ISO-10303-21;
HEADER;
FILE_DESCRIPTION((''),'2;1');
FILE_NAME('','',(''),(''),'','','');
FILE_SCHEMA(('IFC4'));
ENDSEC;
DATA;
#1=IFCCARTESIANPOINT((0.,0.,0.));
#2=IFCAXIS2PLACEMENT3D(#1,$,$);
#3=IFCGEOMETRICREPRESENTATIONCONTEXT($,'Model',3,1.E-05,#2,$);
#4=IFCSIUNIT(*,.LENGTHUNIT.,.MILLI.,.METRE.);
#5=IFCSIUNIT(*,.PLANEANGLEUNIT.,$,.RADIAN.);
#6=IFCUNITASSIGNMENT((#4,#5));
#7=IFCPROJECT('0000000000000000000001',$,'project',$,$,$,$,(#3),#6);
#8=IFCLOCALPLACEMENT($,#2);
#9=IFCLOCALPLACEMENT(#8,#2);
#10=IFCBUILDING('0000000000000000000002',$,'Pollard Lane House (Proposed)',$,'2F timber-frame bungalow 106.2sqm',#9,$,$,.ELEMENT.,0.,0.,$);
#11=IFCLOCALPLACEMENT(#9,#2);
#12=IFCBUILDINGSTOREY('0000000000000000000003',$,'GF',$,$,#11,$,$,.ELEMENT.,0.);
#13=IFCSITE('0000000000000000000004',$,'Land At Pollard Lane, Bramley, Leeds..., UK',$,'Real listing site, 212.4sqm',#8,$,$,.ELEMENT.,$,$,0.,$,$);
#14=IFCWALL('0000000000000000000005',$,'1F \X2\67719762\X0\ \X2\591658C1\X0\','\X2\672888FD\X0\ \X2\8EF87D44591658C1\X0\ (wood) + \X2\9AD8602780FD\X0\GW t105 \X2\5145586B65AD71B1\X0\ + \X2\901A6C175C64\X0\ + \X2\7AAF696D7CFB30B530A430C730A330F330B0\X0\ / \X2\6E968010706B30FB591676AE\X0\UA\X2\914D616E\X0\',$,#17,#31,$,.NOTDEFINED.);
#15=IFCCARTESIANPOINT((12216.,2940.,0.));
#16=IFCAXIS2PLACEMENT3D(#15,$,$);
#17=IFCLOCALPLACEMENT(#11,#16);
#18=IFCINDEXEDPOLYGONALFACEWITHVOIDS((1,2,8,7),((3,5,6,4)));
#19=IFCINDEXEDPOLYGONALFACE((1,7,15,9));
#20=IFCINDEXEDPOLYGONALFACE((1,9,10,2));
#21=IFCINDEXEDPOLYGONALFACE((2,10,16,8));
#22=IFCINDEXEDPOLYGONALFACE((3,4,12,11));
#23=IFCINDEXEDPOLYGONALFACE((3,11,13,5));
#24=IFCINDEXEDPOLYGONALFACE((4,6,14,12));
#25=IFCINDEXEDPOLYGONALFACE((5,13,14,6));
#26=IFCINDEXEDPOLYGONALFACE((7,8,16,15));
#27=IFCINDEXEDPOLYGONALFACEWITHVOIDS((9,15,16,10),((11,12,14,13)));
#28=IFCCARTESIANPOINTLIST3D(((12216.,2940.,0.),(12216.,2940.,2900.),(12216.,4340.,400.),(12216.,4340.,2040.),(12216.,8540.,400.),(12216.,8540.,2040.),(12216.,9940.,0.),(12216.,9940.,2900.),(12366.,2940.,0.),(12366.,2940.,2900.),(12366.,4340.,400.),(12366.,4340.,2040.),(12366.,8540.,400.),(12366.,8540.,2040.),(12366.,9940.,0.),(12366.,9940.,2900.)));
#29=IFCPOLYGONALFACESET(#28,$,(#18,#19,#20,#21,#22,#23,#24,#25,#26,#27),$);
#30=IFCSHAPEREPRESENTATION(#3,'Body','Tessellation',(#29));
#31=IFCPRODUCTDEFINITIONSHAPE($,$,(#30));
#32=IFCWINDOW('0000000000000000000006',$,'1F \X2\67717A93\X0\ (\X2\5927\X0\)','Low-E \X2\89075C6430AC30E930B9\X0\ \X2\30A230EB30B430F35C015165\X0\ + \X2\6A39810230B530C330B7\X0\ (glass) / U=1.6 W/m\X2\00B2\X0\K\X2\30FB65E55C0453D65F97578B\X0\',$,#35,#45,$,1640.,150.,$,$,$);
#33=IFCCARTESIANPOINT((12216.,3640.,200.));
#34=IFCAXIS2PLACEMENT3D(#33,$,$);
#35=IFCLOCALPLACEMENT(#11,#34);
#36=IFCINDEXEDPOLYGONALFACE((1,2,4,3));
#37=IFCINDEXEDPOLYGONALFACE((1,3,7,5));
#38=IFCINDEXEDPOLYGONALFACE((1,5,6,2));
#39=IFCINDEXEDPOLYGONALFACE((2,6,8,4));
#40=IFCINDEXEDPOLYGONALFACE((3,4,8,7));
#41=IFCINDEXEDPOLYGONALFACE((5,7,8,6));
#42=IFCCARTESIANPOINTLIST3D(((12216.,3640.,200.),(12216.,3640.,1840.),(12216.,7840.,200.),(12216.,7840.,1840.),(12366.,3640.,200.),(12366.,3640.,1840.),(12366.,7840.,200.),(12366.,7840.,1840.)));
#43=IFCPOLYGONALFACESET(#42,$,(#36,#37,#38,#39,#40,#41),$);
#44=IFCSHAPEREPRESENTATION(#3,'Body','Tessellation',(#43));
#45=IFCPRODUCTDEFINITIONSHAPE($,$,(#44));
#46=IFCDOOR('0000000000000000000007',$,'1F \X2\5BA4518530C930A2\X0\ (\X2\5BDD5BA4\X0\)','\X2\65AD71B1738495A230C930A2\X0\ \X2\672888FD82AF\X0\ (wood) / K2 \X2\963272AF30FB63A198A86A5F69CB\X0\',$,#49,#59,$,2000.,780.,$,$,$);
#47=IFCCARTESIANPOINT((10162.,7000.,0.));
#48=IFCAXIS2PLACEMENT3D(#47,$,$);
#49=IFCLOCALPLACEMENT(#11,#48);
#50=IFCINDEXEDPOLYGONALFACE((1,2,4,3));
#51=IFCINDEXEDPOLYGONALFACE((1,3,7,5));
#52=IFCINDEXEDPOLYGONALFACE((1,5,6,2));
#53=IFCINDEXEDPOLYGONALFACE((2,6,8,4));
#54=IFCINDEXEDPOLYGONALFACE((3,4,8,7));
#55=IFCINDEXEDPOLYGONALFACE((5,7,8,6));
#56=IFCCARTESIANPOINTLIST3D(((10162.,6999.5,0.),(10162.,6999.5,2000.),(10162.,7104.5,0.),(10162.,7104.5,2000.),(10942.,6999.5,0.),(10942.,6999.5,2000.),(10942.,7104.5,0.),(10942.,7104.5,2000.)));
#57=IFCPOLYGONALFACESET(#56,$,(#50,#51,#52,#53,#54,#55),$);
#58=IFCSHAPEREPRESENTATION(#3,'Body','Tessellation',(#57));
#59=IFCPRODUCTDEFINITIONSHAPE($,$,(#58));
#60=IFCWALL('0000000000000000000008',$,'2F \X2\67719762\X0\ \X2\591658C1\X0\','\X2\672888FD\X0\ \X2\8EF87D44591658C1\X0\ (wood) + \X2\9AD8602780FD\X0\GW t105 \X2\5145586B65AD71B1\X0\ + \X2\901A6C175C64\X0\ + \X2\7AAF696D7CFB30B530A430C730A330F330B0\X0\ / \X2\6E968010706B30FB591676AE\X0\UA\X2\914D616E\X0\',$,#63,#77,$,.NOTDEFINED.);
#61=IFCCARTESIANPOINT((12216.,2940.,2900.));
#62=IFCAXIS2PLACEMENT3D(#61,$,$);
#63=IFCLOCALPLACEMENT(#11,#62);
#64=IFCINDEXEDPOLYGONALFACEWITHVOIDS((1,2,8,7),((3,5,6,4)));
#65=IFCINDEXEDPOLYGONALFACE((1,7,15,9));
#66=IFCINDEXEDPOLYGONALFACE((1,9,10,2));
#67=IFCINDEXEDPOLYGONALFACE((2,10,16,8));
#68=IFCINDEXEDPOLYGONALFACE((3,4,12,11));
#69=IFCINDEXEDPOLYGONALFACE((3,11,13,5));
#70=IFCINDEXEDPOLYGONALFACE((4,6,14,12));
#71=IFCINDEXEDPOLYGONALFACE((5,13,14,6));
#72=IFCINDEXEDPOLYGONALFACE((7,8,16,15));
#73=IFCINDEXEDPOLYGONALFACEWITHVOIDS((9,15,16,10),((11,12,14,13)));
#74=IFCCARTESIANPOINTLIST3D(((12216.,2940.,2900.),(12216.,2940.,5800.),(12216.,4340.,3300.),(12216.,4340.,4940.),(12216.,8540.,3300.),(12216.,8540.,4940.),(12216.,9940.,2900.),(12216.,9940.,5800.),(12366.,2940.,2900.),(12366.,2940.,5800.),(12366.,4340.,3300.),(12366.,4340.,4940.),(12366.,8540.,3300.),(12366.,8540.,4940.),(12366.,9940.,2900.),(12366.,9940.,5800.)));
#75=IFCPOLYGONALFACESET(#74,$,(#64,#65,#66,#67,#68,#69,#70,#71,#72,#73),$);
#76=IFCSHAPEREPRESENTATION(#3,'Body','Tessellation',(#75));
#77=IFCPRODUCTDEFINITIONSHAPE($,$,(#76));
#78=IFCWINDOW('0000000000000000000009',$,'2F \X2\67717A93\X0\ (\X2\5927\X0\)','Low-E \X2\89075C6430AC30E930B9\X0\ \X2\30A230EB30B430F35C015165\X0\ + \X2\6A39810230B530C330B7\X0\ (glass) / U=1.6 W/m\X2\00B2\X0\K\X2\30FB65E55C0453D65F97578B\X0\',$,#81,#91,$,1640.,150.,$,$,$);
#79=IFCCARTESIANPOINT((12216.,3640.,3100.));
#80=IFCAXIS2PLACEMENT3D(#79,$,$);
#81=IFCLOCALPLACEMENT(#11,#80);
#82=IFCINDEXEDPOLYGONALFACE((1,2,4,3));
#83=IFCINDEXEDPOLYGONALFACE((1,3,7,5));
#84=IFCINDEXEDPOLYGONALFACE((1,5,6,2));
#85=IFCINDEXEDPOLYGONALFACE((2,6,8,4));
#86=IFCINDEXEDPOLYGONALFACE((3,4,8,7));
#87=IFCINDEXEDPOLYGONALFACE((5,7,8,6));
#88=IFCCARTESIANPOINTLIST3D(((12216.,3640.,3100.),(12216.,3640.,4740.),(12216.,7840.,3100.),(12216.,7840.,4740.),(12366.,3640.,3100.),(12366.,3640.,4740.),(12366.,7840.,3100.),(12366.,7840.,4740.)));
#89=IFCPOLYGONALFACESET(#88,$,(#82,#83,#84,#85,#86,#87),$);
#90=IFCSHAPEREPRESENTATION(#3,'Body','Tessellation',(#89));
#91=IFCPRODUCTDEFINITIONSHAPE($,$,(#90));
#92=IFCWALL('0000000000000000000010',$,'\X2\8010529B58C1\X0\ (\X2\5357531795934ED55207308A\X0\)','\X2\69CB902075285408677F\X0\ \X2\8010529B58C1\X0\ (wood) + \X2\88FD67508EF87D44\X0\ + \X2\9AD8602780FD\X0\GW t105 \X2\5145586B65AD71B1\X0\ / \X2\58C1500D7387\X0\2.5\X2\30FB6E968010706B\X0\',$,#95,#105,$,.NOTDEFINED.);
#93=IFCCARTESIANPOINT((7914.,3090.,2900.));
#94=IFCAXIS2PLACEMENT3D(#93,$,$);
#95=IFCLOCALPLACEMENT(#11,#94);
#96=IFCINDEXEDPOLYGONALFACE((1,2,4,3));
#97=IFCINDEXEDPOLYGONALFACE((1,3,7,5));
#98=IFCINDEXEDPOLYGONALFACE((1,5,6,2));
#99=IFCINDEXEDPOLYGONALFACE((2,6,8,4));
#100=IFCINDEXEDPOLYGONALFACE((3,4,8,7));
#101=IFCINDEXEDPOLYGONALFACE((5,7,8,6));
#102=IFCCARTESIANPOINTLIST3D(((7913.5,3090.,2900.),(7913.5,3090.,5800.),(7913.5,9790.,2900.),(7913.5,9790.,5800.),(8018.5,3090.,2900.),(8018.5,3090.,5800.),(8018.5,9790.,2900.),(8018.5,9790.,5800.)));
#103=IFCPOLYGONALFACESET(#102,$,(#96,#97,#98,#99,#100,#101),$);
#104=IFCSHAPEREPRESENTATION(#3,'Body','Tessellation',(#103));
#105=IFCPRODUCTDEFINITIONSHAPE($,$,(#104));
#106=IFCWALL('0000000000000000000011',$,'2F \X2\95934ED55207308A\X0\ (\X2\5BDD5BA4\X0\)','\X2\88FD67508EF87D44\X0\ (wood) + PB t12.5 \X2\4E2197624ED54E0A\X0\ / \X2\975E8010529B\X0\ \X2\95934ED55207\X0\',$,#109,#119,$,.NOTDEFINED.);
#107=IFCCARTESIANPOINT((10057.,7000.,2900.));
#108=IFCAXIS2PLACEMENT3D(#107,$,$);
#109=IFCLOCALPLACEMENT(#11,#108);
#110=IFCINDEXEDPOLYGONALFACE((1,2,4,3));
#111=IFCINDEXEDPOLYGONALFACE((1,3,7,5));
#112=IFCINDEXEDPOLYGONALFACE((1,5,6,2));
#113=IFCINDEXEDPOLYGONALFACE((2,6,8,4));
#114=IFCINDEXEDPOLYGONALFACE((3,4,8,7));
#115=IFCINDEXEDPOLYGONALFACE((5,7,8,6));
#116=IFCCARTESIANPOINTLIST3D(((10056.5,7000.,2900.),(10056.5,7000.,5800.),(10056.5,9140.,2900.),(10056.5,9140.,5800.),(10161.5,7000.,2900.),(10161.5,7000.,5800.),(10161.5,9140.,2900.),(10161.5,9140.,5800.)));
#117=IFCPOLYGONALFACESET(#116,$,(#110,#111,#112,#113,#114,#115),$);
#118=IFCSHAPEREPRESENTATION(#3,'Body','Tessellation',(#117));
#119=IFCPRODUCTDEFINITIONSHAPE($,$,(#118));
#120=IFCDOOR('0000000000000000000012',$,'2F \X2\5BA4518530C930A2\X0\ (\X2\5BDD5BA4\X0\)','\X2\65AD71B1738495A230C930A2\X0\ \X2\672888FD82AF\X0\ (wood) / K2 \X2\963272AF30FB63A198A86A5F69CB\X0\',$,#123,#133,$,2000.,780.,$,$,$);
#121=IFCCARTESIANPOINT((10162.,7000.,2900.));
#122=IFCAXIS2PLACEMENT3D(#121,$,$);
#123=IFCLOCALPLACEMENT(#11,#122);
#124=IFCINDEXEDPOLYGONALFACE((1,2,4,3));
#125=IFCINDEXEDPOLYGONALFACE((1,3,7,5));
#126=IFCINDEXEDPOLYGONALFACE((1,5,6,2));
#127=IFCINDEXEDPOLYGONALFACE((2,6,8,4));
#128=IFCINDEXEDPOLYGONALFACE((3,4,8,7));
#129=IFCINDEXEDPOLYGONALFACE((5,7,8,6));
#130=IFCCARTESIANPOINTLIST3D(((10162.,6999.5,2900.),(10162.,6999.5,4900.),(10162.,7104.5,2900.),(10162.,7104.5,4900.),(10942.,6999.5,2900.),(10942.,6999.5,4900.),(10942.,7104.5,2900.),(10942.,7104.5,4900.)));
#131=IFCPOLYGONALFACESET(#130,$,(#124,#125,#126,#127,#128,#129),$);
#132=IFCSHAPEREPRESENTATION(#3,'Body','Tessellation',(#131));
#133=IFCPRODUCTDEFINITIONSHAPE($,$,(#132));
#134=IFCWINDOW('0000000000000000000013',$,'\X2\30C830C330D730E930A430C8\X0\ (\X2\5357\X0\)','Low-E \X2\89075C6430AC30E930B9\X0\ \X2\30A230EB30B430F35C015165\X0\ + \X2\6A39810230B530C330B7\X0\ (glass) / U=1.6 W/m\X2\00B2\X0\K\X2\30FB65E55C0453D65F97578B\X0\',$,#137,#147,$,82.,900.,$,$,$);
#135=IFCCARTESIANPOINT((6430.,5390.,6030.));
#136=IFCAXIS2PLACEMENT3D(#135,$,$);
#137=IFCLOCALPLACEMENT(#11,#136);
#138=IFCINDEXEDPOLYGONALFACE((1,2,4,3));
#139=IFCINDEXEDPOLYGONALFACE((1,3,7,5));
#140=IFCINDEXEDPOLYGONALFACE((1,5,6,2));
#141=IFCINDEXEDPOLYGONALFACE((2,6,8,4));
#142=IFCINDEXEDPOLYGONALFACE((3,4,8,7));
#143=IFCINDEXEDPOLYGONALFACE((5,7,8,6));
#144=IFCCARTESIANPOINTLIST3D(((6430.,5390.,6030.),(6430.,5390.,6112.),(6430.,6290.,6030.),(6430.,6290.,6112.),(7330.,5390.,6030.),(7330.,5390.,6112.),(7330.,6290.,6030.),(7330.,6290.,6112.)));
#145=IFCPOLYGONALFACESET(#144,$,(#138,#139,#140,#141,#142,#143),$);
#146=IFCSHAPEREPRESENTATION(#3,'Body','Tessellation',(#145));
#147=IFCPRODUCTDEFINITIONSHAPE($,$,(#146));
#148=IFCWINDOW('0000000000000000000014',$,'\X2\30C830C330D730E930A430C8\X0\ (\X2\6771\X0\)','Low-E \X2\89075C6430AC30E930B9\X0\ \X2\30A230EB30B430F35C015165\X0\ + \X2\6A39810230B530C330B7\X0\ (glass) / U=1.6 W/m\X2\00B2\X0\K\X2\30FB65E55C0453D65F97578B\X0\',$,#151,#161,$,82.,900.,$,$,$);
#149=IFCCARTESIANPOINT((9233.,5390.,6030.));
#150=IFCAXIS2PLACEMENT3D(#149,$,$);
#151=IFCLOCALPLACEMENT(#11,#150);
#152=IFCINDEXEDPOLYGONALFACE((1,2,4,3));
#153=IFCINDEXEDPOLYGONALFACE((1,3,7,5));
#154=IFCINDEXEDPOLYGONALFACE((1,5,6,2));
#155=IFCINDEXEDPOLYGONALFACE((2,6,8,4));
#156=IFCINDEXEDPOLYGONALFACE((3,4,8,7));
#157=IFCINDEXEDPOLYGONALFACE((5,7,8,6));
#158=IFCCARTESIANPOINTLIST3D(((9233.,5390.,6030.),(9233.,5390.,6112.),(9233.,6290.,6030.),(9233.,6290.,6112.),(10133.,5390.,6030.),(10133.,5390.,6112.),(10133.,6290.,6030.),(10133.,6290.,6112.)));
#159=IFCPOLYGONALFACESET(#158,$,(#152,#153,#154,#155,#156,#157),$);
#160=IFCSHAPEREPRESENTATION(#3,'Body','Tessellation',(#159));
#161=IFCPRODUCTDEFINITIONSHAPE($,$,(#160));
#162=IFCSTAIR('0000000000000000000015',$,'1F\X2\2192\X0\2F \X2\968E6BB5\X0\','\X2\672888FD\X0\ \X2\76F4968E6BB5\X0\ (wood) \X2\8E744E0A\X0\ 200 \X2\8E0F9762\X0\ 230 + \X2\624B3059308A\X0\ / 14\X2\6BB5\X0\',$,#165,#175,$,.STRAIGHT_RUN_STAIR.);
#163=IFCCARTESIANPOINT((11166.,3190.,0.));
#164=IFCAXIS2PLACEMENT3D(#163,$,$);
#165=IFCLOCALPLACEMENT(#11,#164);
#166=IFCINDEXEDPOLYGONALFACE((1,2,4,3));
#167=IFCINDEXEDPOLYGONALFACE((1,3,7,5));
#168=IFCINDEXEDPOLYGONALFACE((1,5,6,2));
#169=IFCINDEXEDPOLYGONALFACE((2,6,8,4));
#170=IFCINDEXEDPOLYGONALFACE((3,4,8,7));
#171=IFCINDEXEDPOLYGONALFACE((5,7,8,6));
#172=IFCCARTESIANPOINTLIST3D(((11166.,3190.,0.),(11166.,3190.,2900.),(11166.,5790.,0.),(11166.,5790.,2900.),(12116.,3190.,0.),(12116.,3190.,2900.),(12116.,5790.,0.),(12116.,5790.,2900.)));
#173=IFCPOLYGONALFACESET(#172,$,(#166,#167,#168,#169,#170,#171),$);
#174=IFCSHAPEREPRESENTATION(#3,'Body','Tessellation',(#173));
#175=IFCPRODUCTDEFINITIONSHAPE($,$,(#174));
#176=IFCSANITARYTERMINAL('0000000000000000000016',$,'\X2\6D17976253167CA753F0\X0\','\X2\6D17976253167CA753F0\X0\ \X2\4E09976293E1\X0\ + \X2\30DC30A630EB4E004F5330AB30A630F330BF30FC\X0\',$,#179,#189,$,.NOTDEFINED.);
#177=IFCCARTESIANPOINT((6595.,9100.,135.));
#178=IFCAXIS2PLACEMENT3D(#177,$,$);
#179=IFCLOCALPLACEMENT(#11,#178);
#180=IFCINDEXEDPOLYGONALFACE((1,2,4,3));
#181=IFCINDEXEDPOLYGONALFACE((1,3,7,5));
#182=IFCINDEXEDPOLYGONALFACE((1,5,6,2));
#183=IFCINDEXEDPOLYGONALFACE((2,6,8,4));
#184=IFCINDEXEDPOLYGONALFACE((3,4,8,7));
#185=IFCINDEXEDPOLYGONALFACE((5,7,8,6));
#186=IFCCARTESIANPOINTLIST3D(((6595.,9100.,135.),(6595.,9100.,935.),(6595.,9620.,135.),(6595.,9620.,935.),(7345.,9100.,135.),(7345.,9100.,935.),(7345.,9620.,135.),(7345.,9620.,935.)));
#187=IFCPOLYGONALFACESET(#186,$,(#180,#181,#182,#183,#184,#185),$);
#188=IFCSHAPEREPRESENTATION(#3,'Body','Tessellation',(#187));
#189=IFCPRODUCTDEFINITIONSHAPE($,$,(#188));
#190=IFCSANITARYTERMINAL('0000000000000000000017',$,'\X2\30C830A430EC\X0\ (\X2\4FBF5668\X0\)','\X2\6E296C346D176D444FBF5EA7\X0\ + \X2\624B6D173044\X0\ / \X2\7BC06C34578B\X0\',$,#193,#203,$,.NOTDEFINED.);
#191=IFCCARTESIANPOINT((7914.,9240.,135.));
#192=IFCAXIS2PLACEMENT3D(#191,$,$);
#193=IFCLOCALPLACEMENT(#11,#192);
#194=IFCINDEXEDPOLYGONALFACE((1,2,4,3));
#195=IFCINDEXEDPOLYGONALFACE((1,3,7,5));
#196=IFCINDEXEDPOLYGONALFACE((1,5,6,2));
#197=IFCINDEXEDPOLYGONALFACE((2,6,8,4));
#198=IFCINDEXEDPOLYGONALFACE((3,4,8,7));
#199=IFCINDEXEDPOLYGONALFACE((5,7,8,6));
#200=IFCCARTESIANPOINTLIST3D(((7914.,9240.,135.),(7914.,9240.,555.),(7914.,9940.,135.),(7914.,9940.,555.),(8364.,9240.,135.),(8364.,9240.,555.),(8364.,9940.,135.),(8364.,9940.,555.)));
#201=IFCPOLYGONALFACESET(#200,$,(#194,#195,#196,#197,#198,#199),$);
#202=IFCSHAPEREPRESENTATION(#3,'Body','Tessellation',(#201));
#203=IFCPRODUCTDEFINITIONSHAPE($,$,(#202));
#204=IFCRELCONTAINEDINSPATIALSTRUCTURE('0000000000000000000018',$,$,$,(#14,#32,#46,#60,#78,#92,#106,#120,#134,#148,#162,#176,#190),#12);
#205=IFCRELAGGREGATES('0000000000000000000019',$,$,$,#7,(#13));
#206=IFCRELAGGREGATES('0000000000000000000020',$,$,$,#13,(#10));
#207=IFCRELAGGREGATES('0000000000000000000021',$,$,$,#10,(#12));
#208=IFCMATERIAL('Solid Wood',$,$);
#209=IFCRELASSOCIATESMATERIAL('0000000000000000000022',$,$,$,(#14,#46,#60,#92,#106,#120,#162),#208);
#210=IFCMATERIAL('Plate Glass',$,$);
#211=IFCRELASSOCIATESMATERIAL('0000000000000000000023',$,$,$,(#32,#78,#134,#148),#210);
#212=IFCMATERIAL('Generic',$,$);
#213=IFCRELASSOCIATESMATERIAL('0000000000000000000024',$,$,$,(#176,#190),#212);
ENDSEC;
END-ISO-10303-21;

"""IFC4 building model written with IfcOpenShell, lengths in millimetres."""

from ifc_helpers import new_model, si_unit, frame, frame_2d, origin, place, context, project, spatial, rectangle, extrude, material, element, fill, save


model = new_model("IFC4")

# Units and contexts
model_context = context("Model", 3, precision=1e-05, world=origin())
ifc_project = project(units=[si_unit("LENGTHUNIT", "METRE", prefix="MILLI"), si_unit("PLANEANGLEUNIT", "RADIAN")], contexts=[model_context])

# Site, building, storey
site_placement = place(None, origin())
site = spatial("IfcSite", under=ifc_project, at=site_placement, Name="Land At Pollard Lane, Bramley, Leeds..., UK", ObjectType="Real listing site, 212.4sqm", CompositionType="ELEMENT", RefElevation=0.0)
building_placement = place(site_placement, origin())
building = spatial("IfcBuilding", under=site, at=building_placement, Name="Pollard Lane House (Proposed)", ObjectType="2F timber-frame bungalow 106.2sqm", CompositionType="ELEMENT", ElevationOfRefHeight=0.0, ElevationOfTerrain=0.0)
storey_placement = place(building_placement, origin())
storey = spatial("IfcBuildingStorey", under=building, at=storey_placement, Name="GF", CompositionType="ELEMENT", Elevation=0.0)

# Wall, opening, window
ifc_material_1 = material(Name="Solid Wood")
wall_1_placement = place(storey_placement, frame((12216.0, 2940.0, 0.0)))
wall_1 = element("IfcWall", 1, at=wall_1_placement, inside=storey, material=ifc_material_1, Name="1F 東面 外壁", Description="木製 軸組外壁 (wood) + 高性能GW t105 充填断熱 + 通気層 + 窯業系サイディング / 準耐火・外皮UA配慮", PredefinedType="NOTDEFINED", context=model_context, shape_type="SweptSolid", body=[
    extrude(rectangle(XDim=150.0, YDim=7000.0, at=frame_2d((75.0, 3500.0))), frame((12216.0, 2940.0, 0.0)), (0.0, 0.0, 1.0), 2900.0),
])
opening_1_placement = place(storey_placement, frame((12216.0, 3640.0, 200.0)))
opening_1 = element("IfcOpeningElement", 2, at=opening_1_placement, cuts=wall_1, PredefinedType="NOTDEFINED", context=model_context, shape_type="SweptSolid", body=[
    extrude(rectangle(XDim=150.0, YDim=4200.0, at=frame_2d((75.0, 2100.0))), frame((12216.0, 3640.0, 200.0)), (0.0, 0.0, 1.0), 1640.0),
])
ifc_material_2 = material(Name="Plate Glass")
window_1_placement = place(storey_placement, frame((12216.0, 3640.0, 200.0)))
window_1 = element("IfcWindow", 3, at=window_1_placement, inside=storey, material=ifc_material_2, Name="1F 東窓 (大)", Description="Low-E 複層ガラス アルゴン封入 + 樹脂サッシ (glass) / U=1.6 W/m²K・日射取得型", OverallHeight=1640.0, OverallWidth=150.0, context=model_context, shape_type="SweptSolid", body=[
    extrude(rectangle(XDim=150.0, YDim=4200.0, at=frame_2d((75.0, 2100.0))), frame((12216.0, 3640.0, 200.0)), (0.0, 0.0, 1.0), 1640.0),
])
fill(opening_1, window_1)

# Door
door_1_placement = place(storey_placement, frame((10162.0, 7000.0, 0.0)))
element("IfcDoor", 4, at=door_1_placement, inside=storey, material=ifc_material_1, Name="1F 室内ドア (寝室)", Description="断熱玄関ドア 木製芯 (wood) / K2 防犯・採風機構", OverallHeight=2000.0, OverallWidth=780.0, context=model_context, shape_type="SweptSolid", body=[
    extrude(rectangle(XDim=780.0, YDim=105.0, at=frame_2d((390.0, 52.0))), frame((10162.0, 7000.0, 0.0)), (0.0, 0.0, 1.0), 2000.0),
])

# Wall, opening, window
wall_2_placement = place(storey_placement, frame((12216.0, 2940.0, 2900.0)))
wall_2 = element("IfcWall", 5, at=wall_2_placement, inside=storey, material=ifc_material_1, Name="2F 東面 外壁", Description="木製 軸組外壁 (wood) + 高性能GW t105 充填断熱 + 通気層 + 窯業系サイディング / 準耐火・外皮UA配慮", PredefinedType="NOTDEFINED", context=model_context, shape_type="SweptSolid", body=[
    extrude(rectangle(XDim=150.0, YDim=7000.0, at=frame_2d((75.0, 3500.0))), frame((12216.0, 2940.0, 2900.0)), (0.0, 0.0, 1.0), 2900.0),
])
opening_2_placement = place(storey_placement, frame((12216.0, 3640.0, 3100.0)))
opening_2 = element("IfcOpeningElement", 6, at=opening_2_placement, cuts=wall_2, PredefinedType="NOTDEFINED", context=model_context, shape_type="SweptSolid", body=[
    extrude(rectangle(XDim=150.0, YDim=4200.0, at=frame_2d((75.0, 2100.0))), frame((12216.0, 3640.0, 3100.0)), (0.0, 0.0, 1.0), 1640.0),
])
window_2_placement = place(storey_placement, frame((12216.0, 3640.0, 3100.0)))
window_2 = element("IfcWindow", 7, at=window_2_placement, inside=storey, material=ifc_material_2, Name="2F 東窓 (大)", Description="Low-E 複層ガラス アルゴン封入 + 樹脂サッシ (glass) / U=1.6 W/m²K・日射取得型", OverallHeight=1640.0, OverallWidth=150.0, context=model_context, shape_type="SweptSolid", body=[
    extrude(rectangle(XDim=150.0, YDim=4200.0, at=frame_2d((75.0, 2100.0))), frame((12216.0, 3640.0, 3100.0)), (0.0, 0.0, 1.0), 1640.0),
])
fill(opening_2, window_2)

# Walls
wall_3_placement = place(storey_placement, frame((7914.0, 3090.0, 2900.0)))
element("IfcWall", 8, at=wall_3_placement, inside=storey, material=ifc_material_1, Name="耐力壁 (南北間仕切り)", Description="構造用合板 耐力壁 (wood) + 製材軸組 + 高性能GW t105 充填断熱 / 壁倍率2.5・準耐火", PredefinedType="NOTDEFINED", context=model_context, shape_type="SweptSolid", body=[
    extrude(rectangle(XDim=105.0, YDim=6700.0, at=frame_2d((52.0, 3350.0))), frame((7914.0, 3090.0, 2900.0)), (0.0, 0.0, 1.0), 2900.0),
])
wall_4_placement = place(storey_placement, frame((10057.0, 7000.0, 2900.0)))
element("IfcWall", 9, at=wall_4_placement, inside=storey, material=ifc_material_1, Name="2F 間仕切り (寝室)", Description="製材軸組 (wood) + PB t12.5 両面仕上 / 非耐力 間仕切", PredefinedType="NOTDEFINED", context=model_context, shape_type="SweptSolid", body=[
    extrude(rectangle(XDim=105.0, YDim=2140.0, at=frame_2d((52.0, 1070.0))), frame((10057.0, 7000.0, 2900.0)), (0.0, 0.0, 1.0), 2900.0),
])

# Door
door_2_placement = place(storey_placement, frame((10162.0, 7000.0, 2900.0)))
element("IfcDoor", 10, at=door_2_placement, inside=storey, material=ifc_material_1, Name="2F 室内ドア (寝室)", Description="断熱玄関ドア 木製芯 (wood) / K2 防犯・採風機構", OverallHeight=2000.0, OverallWidth=780.0, context=model_context, shape_type="SweptSolid", body=[
    extrude(rectangle(XDim=780.0, YDim=105.0, at=frame_2d((390.0, 52.0))), frame((10162.0, 7000.0, 2900.0)), (0.0, 0.0, 1.0), 2000.0),
])

# Windows
window_3_placement = place(storey_placement, frame((6430.0, 5390.0, 6030.0)))
element("IfcWindow", 11, at=window_3_placement, inside=storey, material=ifc_material_2, Name="トップライト (南)", Description="Low-E 複層ガラス アルゴン封入 + 樹脂サッシ (glass) / U=1.6 W/m²K・日射取得型", OverallHeight=82.0, OverallWidth=900.0, context=model_context, shape_type="SweptSolid", body=[
    extrude(rectangle(XDim=900.0, YDim=900.0, at=frame_2d((450.0, 450.0))), frame((6430.0, 5390.0, 6030.0)), (0.0, 0.0, 1.0), 82.0),
])
window_4_placement = place(storey_placement, frame((9233.0, 5390.0, 6030.0)))
element("IfcWindow", 12, at=window_4_placement, inside=storey, material=ifc_material_2, Name="トップライト (東)", Description="Low-E 複層ガラス アルゴン封入 + 樹脂サッシ (glass) / U=1.6 W/m²K・日射取得型", OverallHeight=82.0, OverallWidth=900.0, context=model_context, shape_type="SweptSolid", body=[
    extrude(rectangle(XDim=900.0, YDim=900.0, at=frame_2d((450.0, 450.0))), frame((9233.0, 5390.0, 6030.0)), (0.0, 0.0, 1.0), 82.0),
])

# Stair
stair_placement = place(storey_placement, frame((11166.0, 3190.0, 0.0)))
element("IfcStair", 13, at=stair_placement, inside=storey, material=ifc_material_1, Name="1F→2F 階段", Description="木製 直階段 (wood) 蹴上 200 踏面 230 + 手すり / 14段", PredefinedType="STRAIGHT_RUN_STAIR", context=model_context, shape_type="SweptSolid", body=[
    extrude(rectangle(XDim=950.0, YDim=2600.0, at=frame_2d((475.0, 1300.0))), frame((11166.0, 3190.0, 0.0)), (0.0, 0.0, 1.0), 2900.0),
])

# Sanitary terminals
ifc_material_3 = material(Name="Generic")
sanitary_terminal_1_placement = place(storey_placement, frame((6595.0, 9100.0, 135.0)))
element("IfcSanitaryTerminal", 14, at=sanitary_terminal_1_placement, inside=storey, material=ifc_material_3, Name="洗面化粧台", Description="洗面化粧台 三面鏡 + ボウル一体カウンター", PredefinedType="NOTDEFINED", context=model_context, shape_type="SweptSolid", body=[
    extrude(rectangle(XDim=750.0, YDim=520.0, at=frame_2d((375.0, 260.0))), frame((6595.0, 9100.0, 135.0)), (0.0, 0.0, 1.0), 800.0),
])
sanitary_terminal_2_placement = place(storey_placement, frame((7914.0, 9240.0, 135.0)))
element("IfcSanitaryTerminal", 15, at=sanitary_terminal_2_placement, inside=storey, material=ifc_material_3, Name="トイレ (便器)", Description="温水洗浄便座 + 手洗い / 節水型", PredefinedType="NOTDEFINED", context=model_context, shape_type="SweptSolid", body=[
    extrude(rectangle(XDim=450.0, YDim=700.0, at=frame_2d((225.0, 350.0))), frame((7914.0, 9240.0, 135.0)), (0.0, 0.0, 1.0), 420.0),
])

save(model, "model.ifc")
